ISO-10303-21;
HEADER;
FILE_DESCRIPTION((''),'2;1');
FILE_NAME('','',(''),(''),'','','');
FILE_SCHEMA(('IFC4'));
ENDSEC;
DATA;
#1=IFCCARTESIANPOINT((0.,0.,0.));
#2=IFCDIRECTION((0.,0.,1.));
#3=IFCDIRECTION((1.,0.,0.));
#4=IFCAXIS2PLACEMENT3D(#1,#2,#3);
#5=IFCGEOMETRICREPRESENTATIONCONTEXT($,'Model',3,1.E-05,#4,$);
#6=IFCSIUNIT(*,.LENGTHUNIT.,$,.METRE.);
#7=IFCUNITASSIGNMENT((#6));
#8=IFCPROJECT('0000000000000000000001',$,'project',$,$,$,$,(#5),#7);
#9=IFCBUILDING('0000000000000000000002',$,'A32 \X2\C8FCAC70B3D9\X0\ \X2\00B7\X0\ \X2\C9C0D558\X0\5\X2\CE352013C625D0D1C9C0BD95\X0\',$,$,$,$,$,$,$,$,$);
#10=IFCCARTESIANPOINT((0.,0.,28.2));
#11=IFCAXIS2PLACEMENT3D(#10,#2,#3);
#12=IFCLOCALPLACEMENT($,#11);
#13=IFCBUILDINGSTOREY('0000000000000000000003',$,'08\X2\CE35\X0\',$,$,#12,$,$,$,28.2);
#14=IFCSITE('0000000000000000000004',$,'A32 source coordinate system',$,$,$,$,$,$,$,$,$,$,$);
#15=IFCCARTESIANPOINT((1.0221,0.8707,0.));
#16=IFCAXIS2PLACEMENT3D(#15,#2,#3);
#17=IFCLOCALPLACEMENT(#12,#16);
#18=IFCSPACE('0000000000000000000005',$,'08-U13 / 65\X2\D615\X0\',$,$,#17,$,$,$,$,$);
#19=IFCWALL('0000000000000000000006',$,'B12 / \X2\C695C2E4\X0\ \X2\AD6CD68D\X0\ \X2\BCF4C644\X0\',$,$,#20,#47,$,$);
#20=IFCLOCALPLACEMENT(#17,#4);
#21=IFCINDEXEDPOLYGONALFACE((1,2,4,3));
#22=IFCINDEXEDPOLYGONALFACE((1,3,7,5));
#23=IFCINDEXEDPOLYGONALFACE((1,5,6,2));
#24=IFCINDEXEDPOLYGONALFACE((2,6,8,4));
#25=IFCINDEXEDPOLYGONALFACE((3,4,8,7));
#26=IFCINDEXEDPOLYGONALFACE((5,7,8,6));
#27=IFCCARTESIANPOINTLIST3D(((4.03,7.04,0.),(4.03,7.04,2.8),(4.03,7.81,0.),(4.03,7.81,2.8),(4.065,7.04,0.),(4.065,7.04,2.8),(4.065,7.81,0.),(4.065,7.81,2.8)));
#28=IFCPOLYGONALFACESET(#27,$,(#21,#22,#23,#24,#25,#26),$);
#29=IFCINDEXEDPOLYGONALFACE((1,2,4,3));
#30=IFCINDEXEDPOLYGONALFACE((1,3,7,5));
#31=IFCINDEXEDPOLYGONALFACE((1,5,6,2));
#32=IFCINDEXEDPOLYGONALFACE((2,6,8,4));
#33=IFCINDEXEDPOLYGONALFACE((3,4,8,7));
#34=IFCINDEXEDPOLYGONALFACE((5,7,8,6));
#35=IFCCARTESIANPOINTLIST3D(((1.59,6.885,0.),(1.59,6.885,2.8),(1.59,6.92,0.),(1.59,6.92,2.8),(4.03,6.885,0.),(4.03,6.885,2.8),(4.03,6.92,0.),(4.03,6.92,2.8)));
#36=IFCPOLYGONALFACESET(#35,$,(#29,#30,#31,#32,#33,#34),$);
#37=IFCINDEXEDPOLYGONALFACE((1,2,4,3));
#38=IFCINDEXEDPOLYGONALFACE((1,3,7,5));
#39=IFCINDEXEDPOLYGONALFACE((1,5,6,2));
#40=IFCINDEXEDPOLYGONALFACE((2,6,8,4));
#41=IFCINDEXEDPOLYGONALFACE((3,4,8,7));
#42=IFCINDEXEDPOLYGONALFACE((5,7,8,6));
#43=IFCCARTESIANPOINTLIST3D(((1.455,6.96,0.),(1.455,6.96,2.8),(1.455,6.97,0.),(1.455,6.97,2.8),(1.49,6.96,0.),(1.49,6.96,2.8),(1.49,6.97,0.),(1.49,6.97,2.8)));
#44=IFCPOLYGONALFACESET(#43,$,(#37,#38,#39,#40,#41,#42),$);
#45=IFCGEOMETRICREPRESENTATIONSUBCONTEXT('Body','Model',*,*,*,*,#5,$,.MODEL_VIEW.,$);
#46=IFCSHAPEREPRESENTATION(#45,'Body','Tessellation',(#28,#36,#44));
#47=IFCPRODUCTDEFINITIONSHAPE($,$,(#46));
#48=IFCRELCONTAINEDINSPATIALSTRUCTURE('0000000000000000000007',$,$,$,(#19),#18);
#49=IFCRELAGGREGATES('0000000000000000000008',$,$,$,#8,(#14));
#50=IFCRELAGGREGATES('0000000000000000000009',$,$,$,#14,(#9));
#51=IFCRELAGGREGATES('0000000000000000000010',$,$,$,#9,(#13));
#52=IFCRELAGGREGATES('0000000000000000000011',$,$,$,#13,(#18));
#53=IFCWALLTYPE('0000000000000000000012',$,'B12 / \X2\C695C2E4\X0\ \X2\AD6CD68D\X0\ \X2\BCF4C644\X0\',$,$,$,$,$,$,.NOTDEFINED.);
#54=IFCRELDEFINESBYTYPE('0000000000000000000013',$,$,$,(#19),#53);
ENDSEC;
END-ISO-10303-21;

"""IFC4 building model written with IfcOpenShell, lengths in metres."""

from ifc_helpers import new_model, si_unit, frame, origin, origin_with_axes, place, context, subcontext, project, spatial, polyline, outline, extrude, source, transform, mapped, type_object, type_shapes, element, save


model = new_model("IFC4")

# Units and contexts
model_context = context("Model", 3, precision=1e-05, world=origin_with_axes())
body_context = subcontext(model_context, "Body", "Model", "MODEL_VIEW")
ifc_project = project(units=[si_unit("LENGTHUNIT", "METRE")], contexts=[model_context])

# Site, building, storey, space
storey_placement = place(None, frame((0.0, 0.0, 28.2), z_axis=(0.0, 0.0, 1.0), x_axis=(1.0, 0.0, 0.0)))
space_placement = place(storey_placement, frame((1.0221, 0.8707, 0.0), z_axis=(0.0, 0.0, 1.0), x_axis=(1.0, 0.0, 0.0)))
site = spatial("IfcSite", under=ifc_project, Name="A32 source coordinate system")
building = spatial("IfcBuilding", under=site, Name="A32 주거동 · 지하5층–옥탑지붕")
storey = spatial("IfcBuildingStorey", under=building, at=storey_placement, Name="08층", Elevation=28.2)
space = spatial("IfcSpace", under=storey, at=space_placement, Name="08-U13 / 65형")

# Wall
wall_type_1 = type_object("IfcWallType", Name="B12 / 욕실 구획 보완", PredefinedType="NOTDEFINED")
shared_shape_1 = source(origin(), body_context, "Body", "SweptSolid", [
    extrude(outline(polyline([(4.065, 7.04), (4.03, 7.04), (4.03, 7.81), (4.065, 7.81), (4.065, 7.04)])), origin(), (0.0, 0.0, 1.0), 2.8),
    extrude(outline(polyline([(1.59, 6.92), (4.03, 6.92), (4.03, 6.885), (1.59, 6.885), (1.59, 6.92)])), origin(), (0.0, 0.0, 1.0), 2.8),
    extrude(outline(polyline([(1.455, 6.97), (1.49, 6.97), (1.49, 6.96), (1.455, 6.96), (1.455, 6.97)])), origin(), (0.0, 0.0, 1.0), 2.8),
])
type_shapes(wall_type_1, [shared_shape_1])
wall_1_placement = place(space_placement, origin_with_axes())
element("IfcWall", 1, at=wall_1_placement, inside=space, type_object=wall_type_1, Name="B12 / 욕실 구획 보완", context=body_context, shape_type="MappedRepresentation", body=[
    mapped(shared_shape_1, transform((0.0, 0.0, 0.0), scale=1.0)),
])

save(model, "model.ifc")
